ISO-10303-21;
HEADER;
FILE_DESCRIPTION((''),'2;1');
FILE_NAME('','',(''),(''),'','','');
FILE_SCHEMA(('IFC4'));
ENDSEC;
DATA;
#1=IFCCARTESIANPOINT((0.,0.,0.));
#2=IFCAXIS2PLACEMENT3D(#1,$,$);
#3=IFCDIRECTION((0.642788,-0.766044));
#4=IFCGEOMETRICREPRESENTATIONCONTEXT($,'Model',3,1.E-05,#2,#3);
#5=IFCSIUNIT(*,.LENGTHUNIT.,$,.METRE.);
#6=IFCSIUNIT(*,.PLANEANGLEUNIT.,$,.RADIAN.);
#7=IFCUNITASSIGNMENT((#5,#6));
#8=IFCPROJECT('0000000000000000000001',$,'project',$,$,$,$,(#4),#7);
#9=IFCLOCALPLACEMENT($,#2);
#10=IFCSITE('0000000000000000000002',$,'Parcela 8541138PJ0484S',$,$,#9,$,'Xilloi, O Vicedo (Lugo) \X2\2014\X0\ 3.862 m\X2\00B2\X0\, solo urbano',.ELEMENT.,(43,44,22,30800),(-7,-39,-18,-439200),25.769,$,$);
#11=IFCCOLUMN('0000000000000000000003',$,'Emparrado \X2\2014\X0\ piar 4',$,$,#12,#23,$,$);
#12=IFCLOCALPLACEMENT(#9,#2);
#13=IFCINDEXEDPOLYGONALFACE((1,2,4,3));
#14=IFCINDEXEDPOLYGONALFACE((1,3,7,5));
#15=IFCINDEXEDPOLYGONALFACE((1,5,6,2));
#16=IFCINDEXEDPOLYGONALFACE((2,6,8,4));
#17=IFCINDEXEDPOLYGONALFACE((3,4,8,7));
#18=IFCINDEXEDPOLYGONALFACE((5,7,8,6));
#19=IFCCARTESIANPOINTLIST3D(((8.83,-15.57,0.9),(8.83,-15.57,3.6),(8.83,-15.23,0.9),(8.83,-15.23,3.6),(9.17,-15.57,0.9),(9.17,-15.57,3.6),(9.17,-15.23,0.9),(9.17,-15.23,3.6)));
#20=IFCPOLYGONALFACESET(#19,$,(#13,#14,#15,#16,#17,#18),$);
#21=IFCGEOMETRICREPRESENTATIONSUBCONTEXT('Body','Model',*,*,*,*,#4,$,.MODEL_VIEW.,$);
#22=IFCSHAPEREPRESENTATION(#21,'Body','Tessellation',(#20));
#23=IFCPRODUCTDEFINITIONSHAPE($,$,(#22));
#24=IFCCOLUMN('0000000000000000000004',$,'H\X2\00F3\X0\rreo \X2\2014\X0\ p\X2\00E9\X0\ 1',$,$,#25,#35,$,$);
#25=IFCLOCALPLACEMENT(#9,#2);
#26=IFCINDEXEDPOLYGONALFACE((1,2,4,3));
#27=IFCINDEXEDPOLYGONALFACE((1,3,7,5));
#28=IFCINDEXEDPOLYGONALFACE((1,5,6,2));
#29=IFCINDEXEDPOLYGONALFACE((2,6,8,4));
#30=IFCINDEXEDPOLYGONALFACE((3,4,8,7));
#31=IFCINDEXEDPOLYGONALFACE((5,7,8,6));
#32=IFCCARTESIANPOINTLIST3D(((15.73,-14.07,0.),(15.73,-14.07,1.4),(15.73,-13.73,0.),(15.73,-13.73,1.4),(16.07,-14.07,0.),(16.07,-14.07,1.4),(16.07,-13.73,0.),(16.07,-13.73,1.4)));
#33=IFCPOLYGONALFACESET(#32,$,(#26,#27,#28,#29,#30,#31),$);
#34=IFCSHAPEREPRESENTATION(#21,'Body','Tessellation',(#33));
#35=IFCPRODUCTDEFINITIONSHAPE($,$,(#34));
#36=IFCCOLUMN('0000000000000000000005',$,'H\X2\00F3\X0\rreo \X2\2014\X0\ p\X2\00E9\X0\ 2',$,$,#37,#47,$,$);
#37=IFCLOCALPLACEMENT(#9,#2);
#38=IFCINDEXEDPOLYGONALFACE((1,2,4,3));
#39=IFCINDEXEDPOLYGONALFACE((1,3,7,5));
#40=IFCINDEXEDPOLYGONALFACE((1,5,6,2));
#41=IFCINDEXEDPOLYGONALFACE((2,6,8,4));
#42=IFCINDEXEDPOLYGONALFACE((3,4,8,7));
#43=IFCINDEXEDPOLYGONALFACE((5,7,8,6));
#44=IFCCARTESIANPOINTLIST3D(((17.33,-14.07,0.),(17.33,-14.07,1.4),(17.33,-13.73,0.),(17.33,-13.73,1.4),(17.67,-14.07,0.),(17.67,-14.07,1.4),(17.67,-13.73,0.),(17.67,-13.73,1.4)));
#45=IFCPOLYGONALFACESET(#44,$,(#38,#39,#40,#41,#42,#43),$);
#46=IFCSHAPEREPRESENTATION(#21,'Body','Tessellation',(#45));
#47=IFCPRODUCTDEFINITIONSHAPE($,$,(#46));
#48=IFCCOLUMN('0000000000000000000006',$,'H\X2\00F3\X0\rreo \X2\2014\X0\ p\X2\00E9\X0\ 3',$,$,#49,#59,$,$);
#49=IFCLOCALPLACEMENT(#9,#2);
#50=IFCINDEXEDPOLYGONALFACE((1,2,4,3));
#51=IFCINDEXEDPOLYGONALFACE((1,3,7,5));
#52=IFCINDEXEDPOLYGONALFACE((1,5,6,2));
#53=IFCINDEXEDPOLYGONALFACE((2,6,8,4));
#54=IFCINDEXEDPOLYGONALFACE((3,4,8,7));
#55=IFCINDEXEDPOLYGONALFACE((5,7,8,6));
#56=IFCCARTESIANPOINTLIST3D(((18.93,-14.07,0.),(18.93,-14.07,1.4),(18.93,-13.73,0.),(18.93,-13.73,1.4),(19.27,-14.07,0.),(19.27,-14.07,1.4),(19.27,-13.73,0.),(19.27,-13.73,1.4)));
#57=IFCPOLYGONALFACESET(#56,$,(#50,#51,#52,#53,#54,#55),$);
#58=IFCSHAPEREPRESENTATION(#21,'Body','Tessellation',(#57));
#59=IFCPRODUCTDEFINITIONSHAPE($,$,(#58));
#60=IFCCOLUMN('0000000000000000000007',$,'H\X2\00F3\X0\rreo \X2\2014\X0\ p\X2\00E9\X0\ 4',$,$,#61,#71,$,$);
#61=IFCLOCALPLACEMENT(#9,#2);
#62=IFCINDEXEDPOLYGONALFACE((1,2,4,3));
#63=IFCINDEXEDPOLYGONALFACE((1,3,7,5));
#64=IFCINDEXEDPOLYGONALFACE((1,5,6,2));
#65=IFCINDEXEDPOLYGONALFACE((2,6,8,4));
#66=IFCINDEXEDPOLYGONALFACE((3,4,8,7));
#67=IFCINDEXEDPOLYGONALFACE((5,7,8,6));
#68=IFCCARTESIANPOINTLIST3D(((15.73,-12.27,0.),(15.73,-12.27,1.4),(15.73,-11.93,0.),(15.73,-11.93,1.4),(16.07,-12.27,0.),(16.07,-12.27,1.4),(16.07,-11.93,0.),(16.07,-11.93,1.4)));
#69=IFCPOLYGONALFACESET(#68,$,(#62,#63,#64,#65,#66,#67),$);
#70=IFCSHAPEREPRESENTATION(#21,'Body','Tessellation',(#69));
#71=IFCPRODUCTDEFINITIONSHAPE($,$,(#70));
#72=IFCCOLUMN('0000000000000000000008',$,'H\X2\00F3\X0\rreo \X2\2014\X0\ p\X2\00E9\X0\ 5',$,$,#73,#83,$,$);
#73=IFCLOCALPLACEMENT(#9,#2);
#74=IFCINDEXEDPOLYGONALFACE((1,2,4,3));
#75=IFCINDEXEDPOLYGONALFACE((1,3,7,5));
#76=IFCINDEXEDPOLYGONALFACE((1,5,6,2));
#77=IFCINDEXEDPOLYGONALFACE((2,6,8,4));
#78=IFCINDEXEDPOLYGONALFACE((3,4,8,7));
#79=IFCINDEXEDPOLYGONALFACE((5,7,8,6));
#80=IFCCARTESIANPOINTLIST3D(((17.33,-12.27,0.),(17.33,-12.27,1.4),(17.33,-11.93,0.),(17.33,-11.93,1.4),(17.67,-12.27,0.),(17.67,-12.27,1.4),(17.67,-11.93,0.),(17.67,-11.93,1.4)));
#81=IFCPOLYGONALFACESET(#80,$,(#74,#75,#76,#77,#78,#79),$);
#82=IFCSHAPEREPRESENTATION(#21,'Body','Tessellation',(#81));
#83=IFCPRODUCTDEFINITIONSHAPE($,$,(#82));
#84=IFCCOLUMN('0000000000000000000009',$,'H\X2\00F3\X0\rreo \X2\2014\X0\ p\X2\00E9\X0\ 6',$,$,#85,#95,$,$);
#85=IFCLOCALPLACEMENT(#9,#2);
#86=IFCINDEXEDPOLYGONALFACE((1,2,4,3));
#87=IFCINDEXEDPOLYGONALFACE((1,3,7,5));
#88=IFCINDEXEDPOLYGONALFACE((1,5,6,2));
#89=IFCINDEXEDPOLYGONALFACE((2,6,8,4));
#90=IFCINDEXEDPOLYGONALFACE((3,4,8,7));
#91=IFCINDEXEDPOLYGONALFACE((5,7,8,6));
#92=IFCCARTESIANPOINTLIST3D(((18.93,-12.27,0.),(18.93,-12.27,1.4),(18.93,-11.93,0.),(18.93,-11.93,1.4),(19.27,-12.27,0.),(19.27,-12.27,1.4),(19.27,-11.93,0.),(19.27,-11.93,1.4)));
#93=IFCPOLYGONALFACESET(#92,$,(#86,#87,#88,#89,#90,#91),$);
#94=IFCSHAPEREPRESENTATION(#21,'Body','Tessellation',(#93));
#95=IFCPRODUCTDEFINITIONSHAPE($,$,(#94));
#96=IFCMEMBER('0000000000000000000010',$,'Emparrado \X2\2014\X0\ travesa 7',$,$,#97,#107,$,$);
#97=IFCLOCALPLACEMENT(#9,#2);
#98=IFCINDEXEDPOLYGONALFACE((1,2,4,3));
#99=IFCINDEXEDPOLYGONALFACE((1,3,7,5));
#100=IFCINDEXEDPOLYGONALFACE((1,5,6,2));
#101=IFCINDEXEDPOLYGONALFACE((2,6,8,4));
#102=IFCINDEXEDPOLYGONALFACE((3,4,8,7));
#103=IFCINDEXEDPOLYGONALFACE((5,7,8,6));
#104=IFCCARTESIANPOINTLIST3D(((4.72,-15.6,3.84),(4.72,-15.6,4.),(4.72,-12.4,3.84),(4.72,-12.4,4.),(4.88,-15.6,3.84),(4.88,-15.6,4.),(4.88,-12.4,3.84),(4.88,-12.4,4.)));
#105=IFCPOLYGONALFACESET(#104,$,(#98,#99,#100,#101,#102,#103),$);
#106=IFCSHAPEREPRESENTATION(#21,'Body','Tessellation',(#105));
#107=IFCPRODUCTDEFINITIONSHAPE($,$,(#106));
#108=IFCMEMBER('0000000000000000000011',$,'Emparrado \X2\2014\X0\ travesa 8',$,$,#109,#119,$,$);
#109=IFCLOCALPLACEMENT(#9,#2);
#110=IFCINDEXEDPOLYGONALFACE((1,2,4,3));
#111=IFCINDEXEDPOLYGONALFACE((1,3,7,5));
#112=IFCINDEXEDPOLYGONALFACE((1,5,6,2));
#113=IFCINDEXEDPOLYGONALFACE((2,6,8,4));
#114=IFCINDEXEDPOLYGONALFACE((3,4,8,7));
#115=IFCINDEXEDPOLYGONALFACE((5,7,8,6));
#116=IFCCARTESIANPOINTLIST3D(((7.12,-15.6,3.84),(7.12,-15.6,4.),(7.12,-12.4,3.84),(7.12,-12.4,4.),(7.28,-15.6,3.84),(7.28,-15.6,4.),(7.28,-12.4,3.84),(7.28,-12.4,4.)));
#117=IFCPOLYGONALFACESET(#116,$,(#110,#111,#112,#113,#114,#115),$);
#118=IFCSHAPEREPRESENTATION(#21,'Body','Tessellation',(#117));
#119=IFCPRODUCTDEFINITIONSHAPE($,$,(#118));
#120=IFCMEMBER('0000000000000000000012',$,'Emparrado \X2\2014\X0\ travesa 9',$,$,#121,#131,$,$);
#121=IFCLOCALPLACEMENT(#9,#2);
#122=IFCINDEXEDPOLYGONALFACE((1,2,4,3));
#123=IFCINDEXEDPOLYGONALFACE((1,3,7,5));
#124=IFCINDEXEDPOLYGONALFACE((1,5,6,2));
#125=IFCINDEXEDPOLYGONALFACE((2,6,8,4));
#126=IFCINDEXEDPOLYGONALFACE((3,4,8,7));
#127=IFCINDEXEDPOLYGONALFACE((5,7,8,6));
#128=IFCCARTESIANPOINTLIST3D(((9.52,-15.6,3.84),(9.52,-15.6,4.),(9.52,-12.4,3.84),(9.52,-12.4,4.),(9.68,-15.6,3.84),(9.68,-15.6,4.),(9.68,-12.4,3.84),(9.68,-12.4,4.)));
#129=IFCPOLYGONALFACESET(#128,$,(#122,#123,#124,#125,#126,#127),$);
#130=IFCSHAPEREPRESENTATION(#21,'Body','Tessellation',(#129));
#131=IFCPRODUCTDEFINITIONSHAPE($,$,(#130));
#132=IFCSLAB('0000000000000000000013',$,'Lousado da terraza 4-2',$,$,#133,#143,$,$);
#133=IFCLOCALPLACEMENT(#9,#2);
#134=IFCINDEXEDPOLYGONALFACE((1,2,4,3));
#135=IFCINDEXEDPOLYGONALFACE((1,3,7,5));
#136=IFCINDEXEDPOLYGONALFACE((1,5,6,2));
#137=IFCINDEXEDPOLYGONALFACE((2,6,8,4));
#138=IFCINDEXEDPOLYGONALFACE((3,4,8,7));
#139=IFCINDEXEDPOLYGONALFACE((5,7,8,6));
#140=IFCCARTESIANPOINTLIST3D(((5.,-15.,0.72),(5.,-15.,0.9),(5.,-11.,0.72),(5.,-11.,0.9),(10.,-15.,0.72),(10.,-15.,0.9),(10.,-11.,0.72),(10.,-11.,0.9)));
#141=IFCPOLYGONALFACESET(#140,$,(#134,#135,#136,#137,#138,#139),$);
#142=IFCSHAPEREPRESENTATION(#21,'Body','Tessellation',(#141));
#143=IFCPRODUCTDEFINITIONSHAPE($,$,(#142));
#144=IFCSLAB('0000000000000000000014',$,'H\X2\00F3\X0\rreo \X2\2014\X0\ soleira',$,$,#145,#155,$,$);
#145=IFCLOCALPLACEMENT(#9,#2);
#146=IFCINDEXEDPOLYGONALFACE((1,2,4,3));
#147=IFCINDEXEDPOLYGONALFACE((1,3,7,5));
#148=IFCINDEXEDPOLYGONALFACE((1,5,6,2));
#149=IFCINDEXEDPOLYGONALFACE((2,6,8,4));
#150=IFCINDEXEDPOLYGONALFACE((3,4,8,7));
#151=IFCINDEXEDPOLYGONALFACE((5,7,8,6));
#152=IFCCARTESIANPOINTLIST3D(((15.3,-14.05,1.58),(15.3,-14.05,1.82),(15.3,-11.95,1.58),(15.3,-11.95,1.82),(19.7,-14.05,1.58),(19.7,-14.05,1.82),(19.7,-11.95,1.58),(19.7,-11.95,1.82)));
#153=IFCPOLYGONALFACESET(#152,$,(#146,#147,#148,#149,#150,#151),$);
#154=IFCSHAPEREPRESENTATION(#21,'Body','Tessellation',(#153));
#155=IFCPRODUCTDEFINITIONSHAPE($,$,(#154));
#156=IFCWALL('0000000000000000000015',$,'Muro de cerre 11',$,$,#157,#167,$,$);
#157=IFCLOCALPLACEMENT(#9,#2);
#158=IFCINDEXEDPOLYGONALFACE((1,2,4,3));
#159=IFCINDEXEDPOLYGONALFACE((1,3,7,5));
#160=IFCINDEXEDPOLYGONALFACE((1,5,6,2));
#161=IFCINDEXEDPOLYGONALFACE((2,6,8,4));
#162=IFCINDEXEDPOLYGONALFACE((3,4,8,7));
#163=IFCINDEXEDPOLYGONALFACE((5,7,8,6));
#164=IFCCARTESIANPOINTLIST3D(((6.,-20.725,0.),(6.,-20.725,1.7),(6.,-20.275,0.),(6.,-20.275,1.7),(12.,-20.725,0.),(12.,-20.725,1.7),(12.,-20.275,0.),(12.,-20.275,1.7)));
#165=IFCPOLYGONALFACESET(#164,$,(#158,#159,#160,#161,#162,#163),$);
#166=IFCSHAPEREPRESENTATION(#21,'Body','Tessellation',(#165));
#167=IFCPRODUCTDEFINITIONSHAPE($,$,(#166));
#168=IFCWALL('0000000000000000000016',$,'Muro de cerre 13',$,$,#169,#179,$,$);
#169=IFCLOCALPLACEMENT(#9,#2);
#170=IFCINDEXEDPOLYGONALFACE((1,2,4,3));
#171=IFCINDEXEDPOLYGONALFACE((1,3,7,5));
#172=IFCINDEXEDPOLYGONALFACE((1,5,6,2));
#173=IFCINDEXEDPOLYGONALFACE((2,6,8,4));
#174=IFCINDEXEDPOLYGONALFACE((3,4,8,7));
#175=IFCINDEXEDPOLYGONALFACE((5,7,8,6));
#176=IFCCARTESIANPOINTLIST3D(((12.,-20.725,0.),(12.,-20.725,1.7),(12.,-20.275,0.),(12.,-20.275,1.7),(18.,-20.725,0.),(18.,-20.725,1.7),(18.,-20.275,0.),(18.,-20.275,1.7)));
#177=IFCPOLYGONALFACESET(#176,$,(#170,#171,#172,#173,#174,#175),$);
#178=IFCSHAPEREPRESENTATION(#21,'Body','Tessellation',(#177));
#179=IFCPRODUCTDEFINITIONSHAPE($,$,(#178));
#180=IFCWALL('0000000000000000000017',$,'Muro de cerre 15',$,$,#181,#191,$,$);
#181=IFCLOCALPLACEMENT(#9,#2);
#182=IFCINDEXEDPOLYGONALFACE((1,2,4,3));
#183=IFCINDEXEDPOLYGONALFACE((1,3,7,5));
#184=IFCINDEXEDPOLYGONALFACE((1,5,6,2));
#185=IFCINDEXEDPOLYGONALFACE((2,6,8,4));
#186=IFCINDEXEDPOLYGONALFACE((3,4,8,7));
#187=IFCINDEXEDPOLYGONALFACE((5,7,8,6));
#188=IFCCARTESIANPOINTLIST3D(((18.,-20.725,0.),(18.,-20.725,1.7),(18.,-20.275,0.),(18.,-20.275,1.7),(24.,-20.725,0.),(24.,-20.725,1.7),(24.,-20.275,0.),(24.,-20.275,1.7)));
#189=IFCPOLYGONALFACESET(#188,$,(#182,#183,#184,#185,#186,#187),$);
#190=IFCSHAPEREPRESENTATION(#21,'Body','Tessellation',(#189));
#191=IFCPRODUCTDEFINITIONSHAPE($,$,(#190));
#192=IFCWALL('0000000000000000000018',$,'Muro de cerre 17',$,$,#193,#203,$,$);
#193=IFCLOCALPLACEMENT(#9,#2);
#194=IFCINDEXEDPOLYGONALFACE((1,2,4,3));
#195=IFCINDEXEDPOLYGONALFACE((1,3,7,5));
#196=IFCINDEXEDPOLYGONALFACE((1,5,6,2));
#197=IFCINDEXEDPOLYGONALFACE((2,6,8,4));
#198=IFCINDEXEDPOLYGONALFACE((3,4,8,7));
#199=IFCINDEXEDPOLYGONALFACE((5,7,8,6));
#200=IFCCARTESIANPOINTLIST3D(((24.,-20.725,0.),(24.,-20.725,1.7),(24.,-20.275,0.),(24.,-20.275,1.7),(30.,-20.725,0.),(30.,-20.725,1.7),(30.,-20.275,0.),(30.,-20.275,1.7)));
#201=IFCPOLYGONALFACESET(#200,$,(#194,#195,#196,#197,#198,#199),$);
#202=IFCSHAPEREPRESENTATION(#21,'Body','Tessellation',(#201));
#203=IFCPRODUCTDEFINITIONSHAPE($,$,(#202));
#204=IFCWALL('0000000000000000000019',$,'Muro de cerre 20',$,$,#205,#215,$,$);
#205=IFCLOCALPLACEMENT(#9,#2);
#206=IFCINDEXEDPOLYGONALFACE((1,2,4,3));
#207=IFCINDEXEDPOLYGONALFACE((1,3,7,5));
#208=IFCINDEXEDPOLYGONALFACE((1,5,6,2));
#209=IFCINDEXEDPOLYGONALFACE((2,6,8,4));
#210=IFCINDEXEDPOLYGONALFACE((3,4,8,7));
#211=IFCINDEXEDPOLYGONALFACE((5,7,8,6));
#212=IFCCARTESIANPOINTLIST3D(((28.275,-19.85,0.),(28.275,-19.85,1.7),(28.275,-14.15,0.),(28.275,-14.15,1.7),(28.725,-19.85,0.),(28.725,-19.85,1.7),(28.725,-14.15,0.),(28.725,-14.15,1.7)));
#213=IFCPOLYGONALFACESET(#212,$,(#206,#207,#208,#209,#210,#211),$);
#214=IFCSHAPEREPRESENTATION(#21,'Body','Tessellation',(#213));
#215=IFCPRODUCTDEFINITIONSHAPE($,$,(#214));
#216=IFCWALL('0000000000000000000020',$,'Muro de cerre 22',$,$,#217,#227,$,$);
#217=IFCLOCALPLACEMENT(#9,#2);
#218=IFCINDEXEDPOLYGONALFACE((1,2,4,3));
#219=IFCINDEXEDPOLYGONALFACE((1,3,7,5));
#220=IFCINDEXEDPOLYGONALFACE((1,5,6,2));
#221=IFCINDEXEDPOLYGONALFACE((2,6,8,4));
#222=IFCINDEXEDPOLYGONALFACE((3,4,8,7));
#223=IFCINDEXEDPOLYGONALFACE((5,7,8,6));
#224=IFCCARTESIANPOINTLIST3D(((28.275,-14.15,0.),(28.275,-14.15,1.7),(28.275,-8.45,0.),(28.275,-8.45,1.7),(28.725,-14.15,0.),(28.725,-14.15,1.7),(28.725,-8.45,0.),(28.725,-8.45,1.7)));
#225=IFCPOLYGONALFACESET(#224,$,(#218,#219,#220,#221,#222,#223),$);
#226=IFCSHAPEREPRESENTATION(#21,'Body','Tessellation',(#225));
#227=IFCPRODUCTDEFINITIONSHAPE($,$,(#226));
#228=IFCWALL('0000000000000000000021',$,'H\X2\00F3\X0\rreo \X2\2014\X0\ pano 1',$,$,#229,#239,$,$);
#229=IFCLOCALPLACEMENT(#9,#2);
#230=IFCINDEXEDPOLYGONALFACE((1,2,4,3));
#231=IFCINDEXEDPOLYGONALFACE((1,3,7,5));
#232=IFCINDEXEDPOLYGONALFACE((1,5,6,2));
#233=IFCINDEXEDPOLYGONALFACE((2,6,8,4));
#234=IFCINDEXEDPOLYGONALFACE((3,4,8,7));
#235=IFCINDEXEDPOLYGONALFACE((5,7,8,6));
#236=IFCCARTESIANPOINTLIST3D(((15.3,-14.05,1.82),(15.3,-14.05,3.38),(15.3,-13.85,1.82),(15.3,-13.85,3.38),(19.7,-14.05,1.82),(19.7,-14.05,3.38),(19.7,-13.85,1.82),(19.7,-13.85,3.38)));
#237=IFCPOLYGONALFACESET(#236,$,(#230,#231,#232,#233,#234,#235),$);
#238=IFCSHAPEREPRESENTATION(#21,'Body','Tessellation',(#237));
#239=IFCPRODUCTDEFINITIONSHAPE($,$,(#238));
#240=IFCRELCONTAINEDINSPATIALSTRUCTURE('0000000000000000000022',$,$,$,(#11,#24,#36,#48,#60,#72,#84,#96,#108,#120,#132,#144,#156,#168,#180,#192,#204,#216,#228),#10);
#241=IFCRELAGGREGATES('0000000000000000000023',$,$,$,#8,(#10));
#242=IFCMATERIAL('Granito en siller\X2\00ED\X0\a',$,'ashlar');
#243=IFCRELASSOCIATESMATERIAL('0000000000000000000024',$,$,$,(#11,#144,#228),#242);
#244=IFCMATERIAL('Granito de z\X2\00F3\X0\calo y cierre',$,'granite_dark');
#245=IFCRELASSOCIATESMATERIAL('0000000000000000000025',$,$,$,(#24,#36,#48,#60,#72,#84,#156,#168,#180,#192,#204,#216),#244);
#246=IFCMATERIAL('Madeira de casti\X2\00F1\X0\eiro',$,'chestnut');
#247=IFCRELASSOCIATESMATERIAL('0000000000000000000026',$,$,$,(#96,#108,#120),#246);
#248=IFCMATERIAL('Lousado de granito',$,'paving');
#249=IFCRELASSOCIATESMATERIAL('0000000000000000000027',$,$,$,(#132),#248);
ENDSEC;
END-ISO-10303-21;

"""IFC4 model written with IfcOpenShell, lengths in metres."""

from ifc_helpers import new_model, si_unit, direction, frame, origin, origin_2d, place, context, subcontext, project, spatial, rectangle, extrude, material, element, save


model = new_model("IFC4")

# Units and contexts
model_context = context("Model", 3, precision=1e-05, world=origin(), true_north=direction((0.642788, -0.766044)))
body_context = subcontext(model_context, "Body", "Model", "MODEL_VIEW")
ifc_project = project(units=[si_unit("LENGTHUNIT", "METRE"), si_unit("PLANEANGLEUNIT", "RADIAN")], contexts=[model_context])

# Site
site_placement = place(None, origin())
site = spatial("IfcSite", under=ifc_project, at=site_placement, Name="Parcela 8541138PJ0484S", LongName="Xilloi, O Vicedo (Lugo) — 3.862 m², solo urbano", CompositionType="ELEMENT", RefLatitude=(43, 44, 22, 30800), RefLongitude=(-7, -39, -18, -439200), RefElevation=25.769)

# Columns
ifc_material_1 = material(Name="Granito en sillería", Category="ashlar")
column_placement = place(site_placement, frame((9.0, -15.4, 2.25)))
element("IfcColumn", 1, at=column_placement, inside=site, material=ifc_material_1, Name="Emparrado — piar 4", context=body_context, shape_type="SweptSolid", body=[
    extrude(rectangle(XDim=0.34, YDim=0.34, at=origin_2d()), frame((0.0, 0.0, -1.35)), (0.0, 0.0, 1.0), 2.7),
])
ifc_material_2 = material(Name="Granito de zócalo y cierre", Category="granite_dark")
for number, where, name in (
    (2, (15.9, -13.9, 0.7), "Hórreo — pé 1"),
    (3, (17.5, -13.9, 0.7), "Hórreo — pé 2"),
    (4, (19.1, -13.9, 0.7), "Hórreo — pé 3"),
    (5, (15.9, -12.1, 0.7), "Hórreo — pé 4"),
    (6, (17.5, -12.1, 0.7), "Hórreo — pé 5"),
    (7, (19.1, -12.1, 0.7), "Hórreo — pé 6"),
):
    element("IfcColumn", number, at=place(site_placement, frame(where)), inside=site, material=ifc_material_2, Name=name, context=body_context, shape_type="SweptSolid", body=[
        extrude(rectangle(XDim=0.34, YDim=0.34, at=origin_2d()), frame((0.0, 0.0, -0.7)), (0.0, 0.0, 1.0), 1.4),
    ])

# Members
ifc_material_3 = material(Name="Madeira de castiñeiro", Category="chestnut")
for number, where, name in (
    (8, (4.8, -14.0, 3.92), "Emparrado — travesa 7"),
    (9, (7.2, -14.0, 3.92), "Emparrado — travesa 8"),
    (10, (9.6, -14.0, 3.92), "Emparrado — travesa 9"),
):
    element("IfcMember", number, at=place(site_placement, frame(where)), inside=site, material=ifc_material_3, Name=name, context=body_context, shape_type="SweptSolid", body=[
        extrude(rectangle(XDim=0.16, YDim=3.2, at=origin_2d()), frame((0.0, 0.0, -0.08)), (0.0, 0.0, 1.0), 0.16),
    ])

# Slabs
ifc_material_4 = material(Name="Lousado de granito", Category="paving")
slab_1_placement = place(site_placement, frame((7.5, -13.0, 0.81)))
element("IfcSlab", 11, at=slab_1_placement, inside=site, material=ifc_material_4, Name="Lousado da terraza 4-2", context=body_context, shape_type="SweptSolid", body=[
    extrude(rectangle(XDim=5.0, YDim=4.0, at=origin_2d()), frame((0.0, 0.0, -0.09)), (0.0, 0.0, 1.0), 0.18),
])
slab_2_placement = place(site_placement, frame((17.5, -13.0, 1.7)))
element("IfcSlab", 12, at=slab_2_placement, inside=site, material=ifc_material_1, Name="Hórreo — soleira", context=body_context, shape_type="SweptSolid", body=[
    extrude(rectangle(XDim=4.4, YDim=2.1, at=origin_2d()), frame((0.0, 0.0, -0.12)), (0.0, 0.0, 1.0), 0.24),
])

# Walls
for number, where, name in (
    (13, (9.0, -20.5, 0.85), "Muro de cerre 11"),
    (14, (15.0, -20.5, 0.85), "Muro de cerre 13"),
    (15, (21.0, -20.5, 0.85), "Muro de cerre 15"),
    (16, (27.0, -20.5, 0.85), "Muro de cerre 17"),
):
    element("IfcWall", number, at=place(site_placement, frame(where)), inside=site, material=ifc_material_2, Name=name, context=body_context, shape_type="SweptSolid", body=[
        extrude(rectangle(XDim=6.0, YDim=0.45, at=origin_2d()), frame((0.0, 0.0, -0.85)), (0.0, 0.0, 1.0), 1.7),
    ])
for number, where, name in (
    (17, (28.5, -17.0, 0.85), "Muro de cerre 20"),
    (18, (28.5, -11.3, 0.85), "Muro de cerre 22"),
):
    element("IfcWall", number, at=place(site_placement, frame(where)), inside=site, material=ifc_material_2, Name=name, context=body_context, shape_type="SweptSolid", body=[
        extrude(rectangle(XDim=0.45, YDim=5.7, at=origin_2d()), frame((0.0, 0.0, -0.85)), (0.0, 0.0, 1.0), 1.7),
    ])
for number, where, name in (
    (19, (17.5, -13.95, 2.6), "Hórreo — pano 1"),
):
    element("IfcWall", number, at=place(site_placement, frame(where)), inside=site, material=ifc_material_1, Name=name, context=body_context, shape_type="SweptSolid", body=[
        extrude(rectangle(XDim=4.4, YDim=0.2, at=origin_2d()), frame((0.0, 0.0, -0.78)), (0.0, 0.0, 1.0), 1.56),
    ])

save(model, "model.ifc")
